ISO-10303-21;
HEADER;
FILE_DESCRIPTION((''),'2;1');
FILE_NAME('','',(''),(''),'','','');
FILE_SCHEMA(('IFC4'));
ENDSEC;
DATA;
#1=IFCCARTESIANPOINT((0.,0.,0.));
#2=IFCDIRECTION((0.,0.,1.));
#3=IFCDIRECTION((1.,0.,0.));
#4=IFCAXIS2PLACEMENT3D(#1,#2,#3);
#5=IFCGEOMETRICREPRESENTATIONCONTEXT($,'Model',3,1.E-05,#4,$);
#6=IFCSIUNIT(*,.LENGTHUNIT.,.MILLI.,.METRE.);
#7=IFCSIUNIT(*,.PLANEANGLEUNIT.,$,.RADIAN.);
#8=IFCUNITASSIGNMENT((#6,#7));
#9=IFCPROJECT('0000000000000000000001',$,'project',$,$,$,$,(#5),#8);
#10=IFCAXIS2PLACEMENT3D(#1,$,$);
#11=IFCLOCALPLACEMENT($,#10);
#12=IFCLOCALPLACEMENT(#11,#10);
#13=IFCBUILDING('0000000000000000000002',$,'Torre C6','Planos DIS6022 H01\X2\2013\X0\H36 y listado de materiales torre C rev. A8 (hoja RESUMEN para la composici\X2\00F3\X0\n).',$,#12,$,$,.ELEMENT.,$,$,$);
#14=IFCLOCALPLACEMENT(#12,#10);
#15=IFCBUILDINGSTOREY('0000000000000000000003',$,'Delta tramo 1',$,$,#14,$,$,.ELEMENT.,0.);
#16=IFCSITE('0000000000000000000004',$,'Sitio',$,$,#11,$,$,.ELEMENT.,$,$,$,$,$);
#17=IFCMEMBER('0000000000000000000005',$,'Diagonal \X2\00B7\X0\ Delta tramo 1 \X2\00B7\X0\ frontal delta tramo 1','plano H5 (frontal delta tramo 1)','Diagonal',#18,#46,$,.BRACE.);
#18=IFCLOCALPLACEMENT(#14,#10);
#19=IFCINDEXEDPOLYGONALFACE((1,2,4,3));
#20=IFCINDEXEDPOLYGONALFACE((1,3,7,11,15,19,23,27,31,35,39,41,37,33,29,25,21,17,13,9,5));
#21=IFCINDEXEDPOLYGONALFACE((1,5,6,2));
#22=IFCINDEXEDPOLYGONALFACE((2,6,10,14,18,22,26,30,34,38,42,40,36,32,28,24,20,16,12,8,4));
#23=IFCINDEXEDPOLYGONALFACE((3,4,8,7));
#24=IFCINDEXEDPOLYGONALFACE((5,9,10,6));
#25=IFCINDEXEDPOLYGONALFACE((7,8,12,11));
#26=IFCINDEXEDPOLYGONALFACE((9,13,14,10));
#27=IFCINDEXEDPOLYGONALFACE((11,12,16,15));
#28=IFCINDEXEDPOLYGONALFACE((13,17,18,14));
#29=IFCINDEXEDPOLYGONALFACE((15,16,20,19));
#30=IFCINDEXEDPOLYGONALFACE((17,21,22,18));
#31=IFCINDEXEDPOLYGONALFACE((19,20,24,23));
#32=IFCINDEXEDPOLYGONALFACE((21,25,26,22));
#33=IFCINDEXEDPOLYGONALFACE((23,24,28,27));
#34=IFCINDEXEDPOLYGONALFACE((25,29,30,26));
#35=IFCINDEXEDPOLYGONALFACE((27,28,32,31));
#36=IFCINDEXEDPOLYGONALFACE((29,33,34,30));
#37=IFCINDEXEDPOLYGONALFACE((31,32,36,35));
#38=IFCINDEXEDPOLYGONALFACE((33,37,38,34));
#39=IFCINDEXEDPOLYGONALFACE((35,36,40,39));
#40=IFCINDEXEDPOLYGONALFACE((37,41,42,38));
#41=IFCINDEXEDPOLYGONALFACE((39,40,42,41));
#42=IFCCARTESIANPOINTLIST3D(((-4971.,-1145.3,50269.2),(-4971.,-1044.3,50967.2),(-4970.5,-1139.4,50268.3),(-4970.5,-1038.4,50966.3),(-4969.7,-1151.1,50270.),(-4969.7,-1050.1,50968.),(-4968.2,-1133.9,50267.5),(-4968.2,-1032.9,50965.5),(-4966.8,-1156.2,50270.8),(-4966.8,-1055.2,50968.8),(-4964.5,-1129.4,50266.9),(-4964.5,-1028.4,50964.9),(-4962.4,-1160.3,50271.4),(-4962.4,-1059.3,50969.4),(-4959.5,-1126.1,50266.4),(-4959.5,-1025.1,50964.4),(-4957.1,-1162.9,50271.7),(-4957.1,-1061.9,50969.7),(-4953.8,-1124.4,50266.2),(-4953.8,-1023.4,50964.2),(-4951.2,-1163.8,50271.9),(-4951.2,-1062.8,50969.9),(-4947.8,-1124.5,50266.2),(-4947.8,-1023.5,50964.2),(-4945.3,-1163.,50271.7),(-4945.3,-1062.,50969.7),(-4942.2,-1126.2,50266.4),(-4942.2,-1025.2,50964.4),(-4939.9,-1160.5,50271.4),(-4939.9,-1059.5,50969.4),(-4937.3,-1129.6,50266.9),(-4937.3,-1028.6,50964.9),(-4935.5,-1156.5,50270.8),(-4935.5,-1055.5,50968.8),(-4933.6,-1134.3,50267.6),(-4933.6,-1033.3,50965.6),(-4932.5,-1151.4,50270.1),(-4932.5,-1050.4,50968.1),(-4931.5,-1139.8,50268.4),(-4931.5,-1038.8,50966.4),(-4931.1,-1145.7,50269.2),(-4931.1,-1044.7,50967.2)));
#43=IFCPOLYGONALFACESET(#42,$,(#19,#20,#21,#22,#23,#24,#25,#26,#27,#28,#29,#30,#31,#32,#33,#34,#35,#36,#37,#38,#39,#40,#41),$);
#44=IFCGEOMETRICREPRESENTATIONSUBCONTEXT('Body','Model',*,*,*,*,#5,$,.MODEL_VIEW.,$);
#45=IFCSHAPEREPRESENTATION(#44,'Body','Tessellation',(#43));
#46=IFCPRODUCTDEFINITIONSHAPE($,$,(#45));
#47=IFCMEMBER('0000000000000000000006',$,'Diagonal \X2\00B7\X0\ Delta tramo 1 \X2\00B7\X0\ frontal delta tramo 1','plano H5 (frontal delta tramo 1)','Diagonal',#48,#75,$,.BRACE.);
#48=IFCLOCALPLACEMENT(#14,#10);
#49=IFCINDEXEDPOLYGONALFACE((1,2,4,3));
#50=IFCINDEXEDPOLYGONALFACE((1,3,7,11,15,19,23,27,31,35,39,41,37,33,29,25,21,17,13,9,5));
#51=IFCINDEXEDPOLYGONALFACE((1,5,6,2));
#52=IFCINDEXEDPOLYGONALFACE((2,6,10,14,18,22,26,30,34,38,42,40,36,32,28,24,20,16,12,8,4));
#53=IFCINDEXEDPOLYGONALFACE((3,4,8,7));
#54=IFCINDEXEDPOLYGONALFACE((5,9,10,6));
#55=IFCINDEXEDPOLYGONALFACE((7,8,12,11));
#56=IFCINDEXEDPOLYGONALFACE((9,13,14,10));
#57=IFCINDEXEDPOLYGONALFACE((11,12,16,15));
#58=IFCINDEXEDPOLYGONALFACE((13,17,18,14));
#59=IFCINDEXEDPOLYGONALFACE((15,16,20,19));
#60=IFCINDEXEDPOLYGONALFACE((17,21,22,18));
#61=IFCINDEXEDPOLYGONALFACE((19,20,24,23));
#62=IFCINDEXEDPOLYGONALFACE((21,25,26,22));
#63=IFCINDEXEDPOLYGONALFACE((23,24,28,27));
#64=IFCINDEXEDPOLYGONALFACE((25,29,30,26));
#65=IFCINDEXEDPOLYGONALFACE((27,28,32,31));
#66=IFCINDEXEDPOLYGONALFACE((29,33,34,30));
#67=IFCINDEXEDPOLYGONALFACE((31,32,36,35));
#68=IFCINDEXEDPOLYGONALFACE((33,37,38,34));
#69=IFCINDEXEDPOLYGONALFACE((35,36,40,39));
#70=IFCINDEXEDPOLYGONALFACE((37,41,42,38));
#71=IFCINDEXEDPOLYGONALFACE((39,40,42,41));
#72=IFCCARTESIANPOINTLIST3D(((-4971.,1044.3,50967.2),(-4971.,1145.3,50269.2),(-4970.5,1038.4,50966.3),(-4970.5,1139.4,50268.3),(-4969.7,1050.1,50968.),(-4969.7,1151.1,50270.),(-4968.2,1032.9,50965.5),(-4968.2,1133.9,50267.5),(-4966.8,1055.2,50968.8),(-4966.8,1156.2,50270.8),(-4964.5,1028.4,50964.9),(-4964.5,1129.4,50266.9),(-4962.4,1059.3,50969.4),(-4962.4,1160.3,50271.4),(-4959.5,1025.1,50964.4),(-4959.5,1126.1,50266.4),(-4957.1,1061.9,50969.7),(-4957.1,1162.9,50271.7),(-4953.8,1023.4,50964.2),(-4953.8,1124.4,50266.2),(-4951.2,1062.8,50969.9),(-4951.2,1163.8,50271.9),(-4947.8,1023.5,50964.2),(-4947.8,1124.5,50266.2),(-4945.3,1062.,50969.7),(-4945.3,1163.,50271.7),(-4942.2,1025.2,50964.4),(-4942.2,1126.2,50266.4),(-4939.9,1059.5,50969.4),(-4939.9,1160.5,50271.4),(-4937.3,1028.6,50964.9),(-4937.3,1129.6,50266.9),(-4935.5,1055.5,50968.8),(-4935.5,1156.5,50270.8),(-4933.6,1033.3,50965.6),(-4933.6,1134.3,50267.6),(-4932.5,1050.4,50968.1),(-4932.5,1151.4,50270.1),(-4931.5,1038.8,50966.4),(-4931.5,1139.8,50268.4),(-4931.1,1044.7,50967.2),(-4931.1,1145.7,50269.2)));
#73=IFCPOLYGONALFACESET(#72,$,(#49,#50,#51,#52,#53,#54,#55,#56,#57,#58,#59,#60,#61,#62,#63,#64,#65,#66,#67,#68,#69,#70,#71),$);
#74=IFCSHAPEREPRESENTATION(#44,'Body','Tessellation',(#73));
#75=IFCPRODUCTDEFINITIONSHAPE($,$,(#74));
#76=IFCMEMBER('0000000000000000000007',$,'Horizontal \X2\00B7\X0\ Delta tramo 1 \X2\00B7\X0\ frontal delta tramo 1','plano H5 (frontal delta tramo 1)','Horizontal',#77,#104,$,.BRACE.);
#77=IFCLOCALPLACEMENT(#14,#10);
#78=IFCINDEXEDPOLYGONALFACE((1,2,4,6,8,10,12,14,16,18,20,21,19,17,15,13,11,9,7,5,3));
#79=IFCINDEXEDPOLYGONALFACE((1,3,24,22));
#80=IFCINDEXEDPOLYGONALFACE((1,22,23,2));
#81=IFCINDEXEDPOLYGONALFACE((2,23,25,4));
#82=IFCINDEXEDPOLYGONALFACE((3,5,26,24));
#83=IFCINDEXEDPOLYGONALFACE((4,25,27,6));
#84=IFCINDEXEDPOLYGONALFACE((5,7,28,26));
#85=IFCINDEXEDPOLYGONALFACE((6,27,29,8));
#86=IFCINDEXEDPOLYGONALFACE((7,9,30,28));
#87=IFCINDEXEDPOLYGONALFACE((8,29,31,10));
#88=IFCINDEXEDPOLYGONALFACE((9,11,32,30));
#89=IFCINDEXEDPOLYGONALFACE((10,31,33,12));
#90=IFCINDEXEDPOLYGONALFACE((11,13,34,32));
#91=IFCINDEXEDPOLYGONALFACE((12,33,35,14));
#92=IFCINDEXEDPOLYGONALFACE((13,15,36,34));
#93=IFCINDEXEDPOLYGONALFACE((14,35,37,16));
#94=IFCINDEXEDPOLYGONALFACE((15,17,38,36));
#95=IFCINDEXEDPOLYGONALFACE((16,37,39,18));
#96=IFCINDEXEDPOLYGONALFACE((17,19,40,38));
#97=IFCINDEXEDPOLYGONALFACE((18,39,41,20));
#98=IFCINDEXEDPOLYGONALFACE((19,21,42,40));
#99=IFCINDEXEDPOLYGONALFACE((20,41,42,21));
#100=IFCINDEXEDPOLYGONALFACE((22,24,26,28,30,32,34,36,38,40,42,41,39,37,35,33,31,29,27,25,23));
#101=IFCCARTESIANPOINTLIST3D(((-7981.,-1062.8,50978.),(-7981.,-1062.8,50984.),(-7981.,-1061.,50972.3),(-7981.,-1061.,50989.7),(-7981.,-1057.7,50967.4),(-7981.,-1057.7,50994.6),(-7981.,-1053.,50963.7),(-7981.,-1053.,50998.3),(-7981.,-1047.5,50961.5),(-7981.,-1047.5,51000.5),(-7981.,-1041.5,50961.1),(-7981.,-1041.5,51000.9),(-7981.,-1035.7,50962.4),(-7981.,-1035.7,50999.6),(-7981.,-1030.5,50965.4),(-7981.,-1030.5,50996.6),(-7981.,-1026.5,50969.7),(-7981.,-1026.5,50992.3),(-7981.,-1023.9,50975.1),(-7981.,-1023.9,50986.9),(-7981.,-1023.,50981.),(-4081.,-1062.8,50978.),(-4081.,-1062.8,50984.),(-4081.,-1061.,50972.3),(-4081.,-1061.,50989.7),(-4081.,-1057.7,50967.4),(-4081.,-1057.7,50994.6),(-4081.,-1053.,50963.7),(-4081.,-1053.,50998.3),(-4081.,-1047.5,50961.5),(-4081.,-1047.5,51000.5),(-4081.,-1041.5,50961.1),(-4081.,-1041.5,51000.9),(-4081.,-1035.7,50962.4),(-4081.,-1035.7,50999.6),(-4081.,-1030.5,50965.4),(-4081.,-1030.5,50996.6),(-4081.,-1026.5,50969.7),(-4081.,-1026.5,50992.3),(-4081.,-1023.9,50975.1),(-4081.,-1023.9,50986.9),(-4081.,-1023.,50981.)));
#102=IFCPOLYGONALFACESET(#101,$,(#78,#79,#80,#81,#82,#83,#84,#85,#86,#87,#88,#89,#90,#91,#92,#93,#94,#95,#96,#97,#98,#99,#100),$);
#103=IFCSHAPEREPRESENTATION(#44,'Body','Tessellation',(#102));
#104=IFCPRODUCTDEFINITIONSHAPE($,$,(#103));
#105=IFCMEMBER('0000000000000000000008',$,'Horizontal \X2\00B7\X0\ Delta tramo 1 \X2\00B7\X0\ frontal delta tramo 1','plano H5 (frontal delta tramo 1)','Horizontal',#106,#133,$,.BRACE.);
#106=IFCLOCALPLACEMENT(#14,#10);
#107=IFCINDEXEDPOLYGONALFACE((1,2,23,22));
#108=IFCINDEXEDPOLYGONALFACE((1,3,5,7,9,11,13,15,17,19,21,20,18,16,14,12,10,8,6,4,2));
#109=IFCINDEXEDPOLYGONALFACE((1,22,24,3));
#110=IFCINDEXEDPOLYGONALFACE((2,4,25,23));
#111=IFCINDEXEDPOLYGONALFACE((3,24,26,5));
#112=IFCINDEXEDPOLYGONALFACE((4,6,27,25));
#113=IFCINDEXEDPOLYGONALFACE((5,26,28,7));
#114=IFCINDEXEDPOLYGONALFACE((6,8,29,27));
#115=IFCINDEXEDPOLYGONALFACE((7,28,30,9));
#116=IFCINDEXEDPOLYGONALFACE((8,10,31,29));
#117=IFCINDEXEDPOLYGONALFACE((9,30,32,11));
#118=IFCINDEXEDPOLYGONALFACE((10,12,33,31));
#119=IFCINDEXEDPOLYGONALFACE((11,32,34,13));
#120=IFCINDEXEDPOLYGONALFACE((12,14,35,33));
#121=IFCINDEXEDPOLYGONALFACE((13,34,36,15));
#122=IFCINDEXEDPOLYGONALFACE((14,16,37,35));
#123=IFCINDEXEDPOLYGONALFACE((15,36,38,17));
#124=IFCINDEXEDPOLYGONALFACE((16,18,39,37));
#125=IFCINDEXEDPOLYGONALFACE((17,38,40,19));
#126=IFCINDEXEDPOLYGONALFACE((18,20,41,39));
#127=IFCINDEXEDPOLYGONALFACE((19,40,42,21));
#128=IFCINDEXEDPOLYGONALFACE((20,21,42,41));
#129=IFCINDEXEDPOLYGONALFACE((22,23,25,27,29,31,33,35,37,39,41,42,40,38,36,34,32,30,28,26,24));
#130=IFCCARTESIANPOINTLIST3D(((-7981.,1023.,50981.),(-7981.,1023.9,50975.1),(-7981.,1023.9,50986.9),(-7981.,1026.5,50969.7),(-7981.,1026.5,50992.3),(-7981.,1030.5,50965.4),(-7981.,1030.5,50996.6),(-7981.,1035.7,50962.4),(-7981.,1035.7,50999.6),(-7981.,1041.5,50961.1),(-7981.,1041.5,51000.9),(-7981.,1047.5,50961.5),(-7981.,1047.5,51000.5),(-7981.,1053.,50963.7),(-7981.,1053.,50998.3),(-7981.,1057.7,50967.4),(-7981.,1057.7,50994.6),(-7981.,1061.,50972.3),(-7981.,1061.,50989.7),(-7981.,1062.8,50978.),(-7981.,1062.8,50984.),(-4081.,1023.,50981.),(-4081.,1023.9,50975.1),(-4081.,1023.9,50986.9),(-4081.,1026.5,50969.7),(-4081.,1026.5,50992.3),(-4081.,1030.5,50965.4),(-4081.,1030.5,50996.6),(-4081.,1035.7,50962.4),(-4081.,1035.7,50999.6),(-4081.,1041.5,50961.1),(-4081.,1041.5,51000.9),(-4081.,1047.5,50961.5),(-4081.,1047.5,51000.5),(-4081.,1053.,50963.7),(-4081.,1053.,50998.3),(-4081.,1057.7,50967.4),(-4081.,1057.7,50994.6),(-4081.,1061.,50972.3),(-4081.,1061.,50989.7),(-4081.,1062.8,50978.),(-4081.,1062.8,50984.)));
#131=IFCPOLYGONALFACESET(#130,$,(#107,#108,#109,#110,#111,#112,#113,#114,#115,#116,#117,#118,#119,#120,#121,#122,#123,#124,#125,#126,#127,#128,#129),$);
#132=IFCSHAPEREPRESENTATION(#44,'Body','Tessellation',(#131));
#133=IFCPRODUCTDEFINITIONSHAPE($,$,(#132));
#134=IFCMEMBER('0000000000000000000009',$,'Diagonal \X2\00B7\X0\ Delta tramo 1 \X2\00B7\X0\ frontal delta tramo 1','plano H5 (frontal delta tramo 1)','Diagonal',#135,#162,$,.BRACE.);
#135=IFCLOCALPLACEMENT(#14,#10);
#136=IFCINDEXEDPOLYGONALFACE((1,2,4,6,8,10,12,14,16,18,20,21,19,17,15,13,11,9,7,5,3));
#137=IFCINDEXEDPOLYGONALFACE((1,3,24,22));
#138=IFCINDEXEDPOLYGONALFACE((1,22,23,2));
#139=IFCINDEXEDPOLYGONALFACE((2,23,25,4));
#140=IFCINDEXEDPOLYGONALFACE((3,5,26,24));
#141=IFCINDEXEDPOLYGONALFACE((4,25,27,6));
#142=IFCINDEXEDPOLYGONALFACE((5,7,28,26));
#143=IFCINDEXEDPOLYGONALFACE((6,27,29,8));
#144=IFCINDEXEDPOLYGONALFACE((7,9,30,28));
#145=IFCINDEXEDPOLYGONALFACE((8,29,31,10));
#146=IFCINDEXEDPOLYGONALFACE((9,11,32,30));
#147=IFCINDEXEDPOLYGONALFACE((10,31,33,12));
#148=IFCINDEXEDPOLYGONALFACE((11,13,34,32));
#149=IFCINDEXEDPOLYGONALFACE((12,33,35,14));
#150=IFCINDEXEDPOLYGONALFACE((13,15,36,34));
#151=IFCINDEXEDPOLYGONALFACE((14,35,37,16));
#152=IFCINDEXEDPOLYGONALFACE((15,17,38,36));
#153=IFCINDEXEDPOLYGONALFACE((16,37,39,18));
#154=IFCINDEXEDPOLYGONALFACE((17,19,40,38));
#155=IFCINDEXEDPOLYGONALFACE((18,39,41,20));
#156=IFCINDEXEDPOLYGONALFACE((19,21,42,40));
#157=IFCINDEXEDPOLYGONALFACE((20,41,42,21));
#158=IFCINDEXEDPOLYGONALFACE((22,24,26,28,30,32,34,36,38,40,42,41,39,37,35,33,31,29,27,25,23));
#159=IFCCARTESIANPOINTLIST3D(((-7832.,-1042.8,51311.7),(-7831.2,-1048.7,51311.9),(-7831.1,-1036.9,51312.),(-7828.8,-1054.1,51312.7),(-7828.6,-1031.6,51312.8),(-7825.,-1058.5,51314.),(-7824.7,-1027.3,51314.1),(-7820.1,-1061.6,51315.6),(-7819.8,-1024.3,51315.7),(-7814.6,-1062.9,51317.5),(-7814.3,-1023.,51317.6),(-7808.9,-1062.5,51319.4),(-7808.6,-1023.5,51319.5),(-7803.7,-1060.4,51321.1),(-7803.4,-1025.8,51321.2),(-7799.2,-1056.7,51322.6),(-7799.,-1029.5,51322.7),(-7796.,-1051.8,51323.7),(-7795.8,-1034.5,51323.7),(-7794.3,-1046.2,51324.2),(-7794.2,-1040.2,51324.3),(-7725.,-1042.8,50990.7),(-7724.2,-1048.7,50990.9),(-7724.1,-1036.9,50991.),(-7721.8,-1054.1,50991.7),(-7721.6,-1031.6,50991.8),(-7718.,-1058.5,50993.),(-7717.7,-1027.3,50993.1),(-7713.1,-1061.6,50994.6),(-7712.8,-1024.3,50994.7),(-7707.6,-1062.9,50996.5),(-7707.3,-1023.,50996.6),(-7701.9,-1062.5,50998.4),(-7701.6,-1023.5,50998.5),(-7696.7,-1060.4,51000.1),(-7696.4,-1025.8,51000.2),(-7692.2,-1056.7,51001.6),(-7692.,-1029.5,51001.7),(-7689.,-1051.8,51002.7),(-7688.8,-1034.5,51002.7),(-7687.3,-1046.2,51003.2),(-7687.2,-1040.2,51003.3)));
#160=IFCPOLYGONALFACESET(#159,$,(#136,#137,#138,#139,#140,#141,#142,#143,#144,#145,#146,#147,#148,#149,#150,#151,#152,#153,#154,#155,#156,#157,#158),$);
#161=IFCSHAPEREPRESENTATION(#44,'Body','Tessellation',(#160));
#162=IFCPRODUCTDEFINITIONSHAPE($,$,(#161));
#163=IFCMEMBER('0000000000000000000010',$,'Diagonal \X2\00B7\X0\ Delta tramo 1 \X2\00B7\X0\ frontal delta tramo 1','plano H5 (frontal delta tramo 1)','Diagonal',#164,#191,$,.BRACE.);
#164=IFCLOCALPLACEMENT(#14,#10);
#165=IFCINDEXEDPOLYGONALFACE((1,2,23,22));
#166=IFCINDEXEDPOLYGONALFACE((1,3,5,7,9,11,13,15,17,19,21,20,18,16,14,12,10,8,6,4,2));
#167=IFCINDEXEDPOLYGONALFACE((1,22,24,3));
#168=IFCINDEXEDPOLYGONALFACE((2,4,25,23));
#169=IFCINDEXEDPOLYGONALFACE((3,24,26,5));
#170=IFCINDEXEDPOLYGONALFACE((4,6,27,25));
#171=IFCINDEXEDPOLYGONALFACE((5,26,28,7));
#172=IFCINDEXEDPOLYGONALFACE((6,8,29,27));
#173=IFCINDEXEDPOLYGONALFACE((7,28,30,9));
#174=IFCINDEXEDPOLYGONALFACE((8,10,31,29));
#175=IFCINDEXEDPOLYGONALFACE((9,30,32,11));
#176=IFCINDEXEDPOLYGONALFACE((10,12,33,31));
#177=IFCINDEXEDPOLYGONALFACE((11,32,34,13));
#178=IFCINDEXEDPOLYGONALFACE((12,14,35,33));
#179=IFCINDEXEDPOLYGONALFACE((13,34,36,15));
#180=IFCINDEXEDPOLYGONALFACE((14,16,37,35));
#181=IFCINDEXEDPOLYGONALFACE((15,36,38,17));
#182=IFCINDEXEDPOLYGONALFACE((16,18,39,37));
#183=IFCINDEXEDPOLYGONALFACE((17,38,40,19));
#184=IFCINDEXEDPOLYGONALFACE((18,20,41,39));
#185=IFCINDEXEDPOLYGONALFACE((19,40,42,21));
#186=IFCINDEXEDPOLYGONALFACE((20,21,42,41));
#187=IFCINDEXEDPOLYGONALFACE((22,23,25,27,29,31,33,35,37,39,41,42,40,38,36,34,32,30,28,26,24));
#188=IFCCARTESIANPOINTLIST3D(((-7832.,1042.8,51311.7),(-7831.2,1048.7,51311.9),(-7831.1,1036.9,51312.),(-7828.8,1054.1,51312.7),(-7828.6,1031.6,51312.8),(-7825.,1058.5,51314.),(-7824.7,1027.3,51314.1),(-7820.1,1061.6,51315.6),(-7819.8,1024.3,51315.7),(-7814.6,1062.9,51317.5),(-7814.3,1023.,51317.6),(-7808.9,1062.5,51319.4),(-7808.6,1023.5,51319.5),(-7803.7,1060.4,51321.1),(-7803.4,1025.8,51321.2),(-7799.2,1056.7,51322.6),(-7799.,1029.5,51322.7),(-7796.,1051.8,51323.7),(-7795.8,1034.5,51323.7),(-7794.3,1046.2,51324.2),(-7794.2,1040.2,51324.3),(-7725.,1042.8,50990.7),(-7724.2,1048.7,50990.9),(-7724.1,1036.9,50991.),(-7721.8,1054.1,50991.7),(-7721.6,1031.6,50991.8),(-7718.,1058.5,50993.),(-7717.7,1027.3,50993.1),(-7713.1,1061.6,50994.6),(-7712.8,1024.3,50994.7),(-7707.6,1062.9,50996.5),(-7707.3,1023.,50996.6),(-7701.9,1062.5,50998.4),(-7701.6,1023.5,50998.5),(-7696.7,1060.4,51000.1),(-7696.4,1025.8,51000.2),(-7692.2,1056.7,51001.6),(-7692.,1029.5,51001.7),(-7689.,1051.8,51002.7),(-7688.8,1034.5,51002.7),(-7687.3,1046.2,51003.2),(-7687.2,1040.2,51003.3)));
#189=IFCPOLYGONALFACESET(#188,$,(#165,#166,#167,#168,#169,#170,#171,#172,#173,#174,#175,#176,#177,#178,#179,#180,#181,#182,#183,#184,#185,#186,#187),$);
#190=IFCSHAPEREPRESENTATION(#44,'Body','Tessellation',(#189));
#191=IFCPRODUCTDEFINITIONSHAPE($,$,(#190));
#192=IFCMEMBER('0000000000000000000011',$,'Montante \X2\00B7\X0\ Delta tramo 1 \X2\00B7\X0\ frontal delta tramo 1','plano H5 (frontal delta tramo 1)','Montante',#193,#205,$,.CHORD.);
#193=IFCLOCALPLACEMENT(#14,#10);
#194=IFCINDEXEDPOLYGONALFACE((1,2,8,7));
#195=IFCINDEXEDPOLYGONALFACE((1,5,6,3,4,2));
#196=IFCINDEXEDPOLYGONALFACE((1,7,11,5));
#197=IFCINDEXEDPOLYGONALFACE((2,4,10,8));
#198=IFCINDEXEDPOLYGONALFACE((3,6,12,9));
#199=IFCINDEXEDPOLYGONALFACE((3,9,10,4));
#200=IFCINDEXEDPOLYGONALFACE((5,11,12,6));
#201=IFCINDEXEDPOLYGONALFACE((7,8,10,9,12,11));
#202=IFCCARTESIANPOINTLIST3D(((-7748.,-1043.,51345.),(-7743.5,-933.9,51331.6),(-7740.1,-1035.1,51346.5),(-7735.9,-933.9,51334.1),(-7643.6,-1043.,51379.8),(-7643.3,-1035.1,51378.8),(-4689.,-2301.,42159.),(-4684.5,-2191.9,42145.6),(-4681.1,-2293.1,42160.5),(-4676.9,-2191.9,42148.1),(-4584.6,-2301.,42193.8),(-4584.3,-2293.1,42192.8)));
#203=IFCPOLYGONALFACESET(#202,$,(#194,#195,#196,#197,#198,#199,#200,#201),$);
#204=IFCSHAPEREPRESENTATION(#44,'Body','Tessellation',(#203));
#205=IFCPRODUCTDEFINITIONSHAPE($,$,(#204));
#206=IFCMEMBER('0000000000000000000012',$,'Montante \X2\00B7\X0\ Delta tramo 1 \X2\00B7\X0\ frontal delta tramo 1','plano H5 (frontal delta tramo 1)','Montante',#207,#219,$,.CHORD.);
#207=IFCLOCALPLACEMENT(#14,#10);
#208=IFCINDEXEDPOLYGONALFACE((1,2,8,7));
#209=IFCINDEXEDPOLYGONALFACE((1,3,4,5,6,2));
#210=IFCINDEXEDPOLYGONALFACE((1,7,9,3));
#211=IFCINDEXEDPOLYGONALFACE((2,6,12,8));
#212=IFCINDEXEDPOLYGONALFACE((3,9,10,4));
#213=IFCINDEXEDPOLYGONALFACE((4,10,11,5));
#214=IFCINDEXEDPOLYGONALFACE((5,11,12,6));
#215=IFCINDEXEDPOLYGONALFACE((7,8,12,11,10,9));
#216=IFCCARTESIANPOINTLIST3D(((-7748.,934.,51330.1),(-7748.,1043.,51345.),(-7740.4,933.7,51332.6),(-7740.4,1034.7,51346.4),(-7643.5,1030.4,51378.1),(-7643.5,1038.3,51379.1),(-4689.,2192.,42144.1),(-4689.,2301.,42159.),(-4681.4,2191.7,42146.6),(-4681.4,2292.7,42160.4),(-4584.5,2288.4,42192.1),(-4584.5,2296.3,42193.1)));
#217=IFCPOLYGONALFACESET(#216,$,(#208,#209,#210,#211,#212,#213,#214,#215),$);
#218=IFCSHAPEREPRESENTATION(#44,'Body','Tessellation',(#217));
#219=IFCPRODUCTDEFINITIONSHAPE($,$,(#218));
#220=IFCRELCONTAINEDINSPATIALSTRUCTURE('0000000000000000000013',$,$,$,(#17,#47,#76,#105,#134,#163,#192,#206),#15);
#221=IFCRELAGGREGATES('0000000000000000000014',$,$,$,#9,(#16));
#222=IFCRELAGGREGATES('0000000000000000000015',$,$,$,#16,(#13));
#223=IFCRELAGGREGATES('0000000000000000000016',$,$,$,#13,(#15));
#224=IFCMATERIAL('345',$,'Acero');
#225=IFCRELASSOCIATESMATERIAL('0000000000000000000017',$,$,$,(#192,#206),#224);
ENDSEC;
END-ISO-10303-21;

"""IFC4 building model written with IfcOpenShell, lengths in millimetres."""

from ifc_helpers import new_model, si_unit, frame, frame_2d, origin, origin_with_axes, place, context, subcontext, project, spatial, circle, l_section, extrude, material, element, save


model = new_model("IFC4")

# Units and contexts
model_context = context("Model", 3, precision=1e-05, world=origin_with_axes())
body_context = subcontext(model_context, "Body", "Model", "MODEL_VIEW")
ifc_project = project(units=[si_unit("LENGTHUNIT", "METRE", prefix="MILLI"), si_unit("PLANEANGLEUNIT", "RADIAN")], contexts=[model_context])

# Site, building, storey
site_placement = place(None, origin())
site = spatial("IfcSite", under=ifc_project, at=site_placement, Name="Sitio", CompositionType="ELEMENT")
building_placement = place(site_placement, origin())
building = spatial("IfcBuilding", under=site, at=building_placement, Name="Torre C6", Description="Planos DIS6022 H01–H36 y listado de materiales torre C rev. A8 (hoja RESUMEN para la composición).", CompositionType="ELEMENT")
storey_placement = place(building_placement, origin())
storey = spatial("IfcBuildingStorey", under=building, at=storey_placement, Name="Delta tramo 1", CompositionType="ELEMENT", Elevation=0.0)

# Members
for number, where, z_axis, x_axis, name in (
    (1, (-4951.0, -1144.0, 50269.0), (0.0, 0.143208, 0.989693), (0.976933, 0.211345, -0.030581), "Diagonal · Delta tramo 1 · frontal delta tramo 1"),
    (2, (-4951.0, 1144.0, 50269.0), (0.0, -0.143208, 0.989693), (0.976933, -0.211345, -0.030581), "Diagonal · Delta tramo 1 · frontal delta tramo 1"),
):
    element("IfcMember", number, at=place(storey_placement, frame(where, z_axis=z_axis, x_axis=x_axis)), inside=storey, Name=name, Description="plano H5 (frontal delta tramo 1)", ObjectType="Diagonal", PredefinedType="BRACE", context=body_context, shape_type="SweptSolid", body=[
        extrude(circle(Radius=20.0), None, (0.0, 0.0, 1.0), 705.3),
    ])
for number, where, z_axis, x_axis, name in (
    (3, (-4081.0, -1043.0, 50981.0), (-1.0, 0.0, 0.0), (0.0, 1.0, 0.0), "Horizontal · Delta tramo 1 · frontal delta tramo 1"),
    (4, (-4081.0, 1043.0, 50981.0), (-1.0, 0.0, 0.0), (0.0, -1.0, 0.0), "Horizontal · Delta tramo 1 · frontal delta tramo 1"),
):
    element("IfcMember", number, at=place(storey_placement, frame(where, z_axis=z_axis, x_axis=x_axis)), inside=storey, Name=name, Description="plano H5 (frontal delta tramo 1)", ObjectType="Horizontal", PredefinedType="BRACE", context=body_context, shape_type="SweptSolid", body=[
        extrude(circle(Radius=20.0), None, (0.0, 0.0, 1.0), 3900.0),
    ])
for number, where, z_axis, x_axis, name in (
    (5, (-7706.0, -1043.0, 50997.0), (-0.316228, 0.0, 0.948683), (0.939302, 0.140286, 0.313101), "Diagonal · Delta tramo 1 · frontal delta tramo 1"),
    (6, (-7706.0, 1043.0, 50997.0), (-0.316228, 0.0, 0.948683), (0.939302, -0.140286, 0.313101), "Diagonal · Delta tramo 1 · frontal delta tramo 1"),
):
    element("IfcMember", number, at=place(storey_placement, frame(where, z_axis=z_axis, x_axis=x_axis)), inside=storey, Name=name, Description="plano H5 (frontal delta tramo 1)", ObjectType="Diagonal", PredefinedType="BRACE", context=body_context, shape_type="SweptSolid", body=[
        extrude(circle(Radius=20.0), None, (0.0, 0.0, 1.0), 338.4),
    ])
ifc_material = material(Name="345", Category="Acero")
for number, where, z_axis, x_axis, name in (
    (7, (-7748.0, -1043.0, 51345.0), (0.313315, -0.128849, -0.940867), (0.04071, 0.991664, -0.122249), "Montante · Delta tramo 1 · frontal delta tramo 1"),
    (8, (-7748.0, 1043.0, 51345.0), (0.313315, 0.128849, -0.940867), (0.949649, -0.042511, 0.310418), "Montante · Delta tramo 1 · frontal delta tramo 1"),
):
    element("IfcMember", number, at=place(storey_placement, frame(where, z_axis=z_axis, x_axis=x_axis)), inside=storey, material=ifc_material, Name=name, Description="plano H5 (frontal delta tramo 1)", ObjectType="Montante", PredefinedType="CHORD", context=body_context, shape_type="SweptSolid", body=[
        extrude(l_section(Depth=110.0, Width=110.0, Thickness=8.0, at=frame_2d((55.0, 55.0))), None, (0.0, 0.0, 1.0), 9763.3),
    ])

save(model, "model.ifc")
